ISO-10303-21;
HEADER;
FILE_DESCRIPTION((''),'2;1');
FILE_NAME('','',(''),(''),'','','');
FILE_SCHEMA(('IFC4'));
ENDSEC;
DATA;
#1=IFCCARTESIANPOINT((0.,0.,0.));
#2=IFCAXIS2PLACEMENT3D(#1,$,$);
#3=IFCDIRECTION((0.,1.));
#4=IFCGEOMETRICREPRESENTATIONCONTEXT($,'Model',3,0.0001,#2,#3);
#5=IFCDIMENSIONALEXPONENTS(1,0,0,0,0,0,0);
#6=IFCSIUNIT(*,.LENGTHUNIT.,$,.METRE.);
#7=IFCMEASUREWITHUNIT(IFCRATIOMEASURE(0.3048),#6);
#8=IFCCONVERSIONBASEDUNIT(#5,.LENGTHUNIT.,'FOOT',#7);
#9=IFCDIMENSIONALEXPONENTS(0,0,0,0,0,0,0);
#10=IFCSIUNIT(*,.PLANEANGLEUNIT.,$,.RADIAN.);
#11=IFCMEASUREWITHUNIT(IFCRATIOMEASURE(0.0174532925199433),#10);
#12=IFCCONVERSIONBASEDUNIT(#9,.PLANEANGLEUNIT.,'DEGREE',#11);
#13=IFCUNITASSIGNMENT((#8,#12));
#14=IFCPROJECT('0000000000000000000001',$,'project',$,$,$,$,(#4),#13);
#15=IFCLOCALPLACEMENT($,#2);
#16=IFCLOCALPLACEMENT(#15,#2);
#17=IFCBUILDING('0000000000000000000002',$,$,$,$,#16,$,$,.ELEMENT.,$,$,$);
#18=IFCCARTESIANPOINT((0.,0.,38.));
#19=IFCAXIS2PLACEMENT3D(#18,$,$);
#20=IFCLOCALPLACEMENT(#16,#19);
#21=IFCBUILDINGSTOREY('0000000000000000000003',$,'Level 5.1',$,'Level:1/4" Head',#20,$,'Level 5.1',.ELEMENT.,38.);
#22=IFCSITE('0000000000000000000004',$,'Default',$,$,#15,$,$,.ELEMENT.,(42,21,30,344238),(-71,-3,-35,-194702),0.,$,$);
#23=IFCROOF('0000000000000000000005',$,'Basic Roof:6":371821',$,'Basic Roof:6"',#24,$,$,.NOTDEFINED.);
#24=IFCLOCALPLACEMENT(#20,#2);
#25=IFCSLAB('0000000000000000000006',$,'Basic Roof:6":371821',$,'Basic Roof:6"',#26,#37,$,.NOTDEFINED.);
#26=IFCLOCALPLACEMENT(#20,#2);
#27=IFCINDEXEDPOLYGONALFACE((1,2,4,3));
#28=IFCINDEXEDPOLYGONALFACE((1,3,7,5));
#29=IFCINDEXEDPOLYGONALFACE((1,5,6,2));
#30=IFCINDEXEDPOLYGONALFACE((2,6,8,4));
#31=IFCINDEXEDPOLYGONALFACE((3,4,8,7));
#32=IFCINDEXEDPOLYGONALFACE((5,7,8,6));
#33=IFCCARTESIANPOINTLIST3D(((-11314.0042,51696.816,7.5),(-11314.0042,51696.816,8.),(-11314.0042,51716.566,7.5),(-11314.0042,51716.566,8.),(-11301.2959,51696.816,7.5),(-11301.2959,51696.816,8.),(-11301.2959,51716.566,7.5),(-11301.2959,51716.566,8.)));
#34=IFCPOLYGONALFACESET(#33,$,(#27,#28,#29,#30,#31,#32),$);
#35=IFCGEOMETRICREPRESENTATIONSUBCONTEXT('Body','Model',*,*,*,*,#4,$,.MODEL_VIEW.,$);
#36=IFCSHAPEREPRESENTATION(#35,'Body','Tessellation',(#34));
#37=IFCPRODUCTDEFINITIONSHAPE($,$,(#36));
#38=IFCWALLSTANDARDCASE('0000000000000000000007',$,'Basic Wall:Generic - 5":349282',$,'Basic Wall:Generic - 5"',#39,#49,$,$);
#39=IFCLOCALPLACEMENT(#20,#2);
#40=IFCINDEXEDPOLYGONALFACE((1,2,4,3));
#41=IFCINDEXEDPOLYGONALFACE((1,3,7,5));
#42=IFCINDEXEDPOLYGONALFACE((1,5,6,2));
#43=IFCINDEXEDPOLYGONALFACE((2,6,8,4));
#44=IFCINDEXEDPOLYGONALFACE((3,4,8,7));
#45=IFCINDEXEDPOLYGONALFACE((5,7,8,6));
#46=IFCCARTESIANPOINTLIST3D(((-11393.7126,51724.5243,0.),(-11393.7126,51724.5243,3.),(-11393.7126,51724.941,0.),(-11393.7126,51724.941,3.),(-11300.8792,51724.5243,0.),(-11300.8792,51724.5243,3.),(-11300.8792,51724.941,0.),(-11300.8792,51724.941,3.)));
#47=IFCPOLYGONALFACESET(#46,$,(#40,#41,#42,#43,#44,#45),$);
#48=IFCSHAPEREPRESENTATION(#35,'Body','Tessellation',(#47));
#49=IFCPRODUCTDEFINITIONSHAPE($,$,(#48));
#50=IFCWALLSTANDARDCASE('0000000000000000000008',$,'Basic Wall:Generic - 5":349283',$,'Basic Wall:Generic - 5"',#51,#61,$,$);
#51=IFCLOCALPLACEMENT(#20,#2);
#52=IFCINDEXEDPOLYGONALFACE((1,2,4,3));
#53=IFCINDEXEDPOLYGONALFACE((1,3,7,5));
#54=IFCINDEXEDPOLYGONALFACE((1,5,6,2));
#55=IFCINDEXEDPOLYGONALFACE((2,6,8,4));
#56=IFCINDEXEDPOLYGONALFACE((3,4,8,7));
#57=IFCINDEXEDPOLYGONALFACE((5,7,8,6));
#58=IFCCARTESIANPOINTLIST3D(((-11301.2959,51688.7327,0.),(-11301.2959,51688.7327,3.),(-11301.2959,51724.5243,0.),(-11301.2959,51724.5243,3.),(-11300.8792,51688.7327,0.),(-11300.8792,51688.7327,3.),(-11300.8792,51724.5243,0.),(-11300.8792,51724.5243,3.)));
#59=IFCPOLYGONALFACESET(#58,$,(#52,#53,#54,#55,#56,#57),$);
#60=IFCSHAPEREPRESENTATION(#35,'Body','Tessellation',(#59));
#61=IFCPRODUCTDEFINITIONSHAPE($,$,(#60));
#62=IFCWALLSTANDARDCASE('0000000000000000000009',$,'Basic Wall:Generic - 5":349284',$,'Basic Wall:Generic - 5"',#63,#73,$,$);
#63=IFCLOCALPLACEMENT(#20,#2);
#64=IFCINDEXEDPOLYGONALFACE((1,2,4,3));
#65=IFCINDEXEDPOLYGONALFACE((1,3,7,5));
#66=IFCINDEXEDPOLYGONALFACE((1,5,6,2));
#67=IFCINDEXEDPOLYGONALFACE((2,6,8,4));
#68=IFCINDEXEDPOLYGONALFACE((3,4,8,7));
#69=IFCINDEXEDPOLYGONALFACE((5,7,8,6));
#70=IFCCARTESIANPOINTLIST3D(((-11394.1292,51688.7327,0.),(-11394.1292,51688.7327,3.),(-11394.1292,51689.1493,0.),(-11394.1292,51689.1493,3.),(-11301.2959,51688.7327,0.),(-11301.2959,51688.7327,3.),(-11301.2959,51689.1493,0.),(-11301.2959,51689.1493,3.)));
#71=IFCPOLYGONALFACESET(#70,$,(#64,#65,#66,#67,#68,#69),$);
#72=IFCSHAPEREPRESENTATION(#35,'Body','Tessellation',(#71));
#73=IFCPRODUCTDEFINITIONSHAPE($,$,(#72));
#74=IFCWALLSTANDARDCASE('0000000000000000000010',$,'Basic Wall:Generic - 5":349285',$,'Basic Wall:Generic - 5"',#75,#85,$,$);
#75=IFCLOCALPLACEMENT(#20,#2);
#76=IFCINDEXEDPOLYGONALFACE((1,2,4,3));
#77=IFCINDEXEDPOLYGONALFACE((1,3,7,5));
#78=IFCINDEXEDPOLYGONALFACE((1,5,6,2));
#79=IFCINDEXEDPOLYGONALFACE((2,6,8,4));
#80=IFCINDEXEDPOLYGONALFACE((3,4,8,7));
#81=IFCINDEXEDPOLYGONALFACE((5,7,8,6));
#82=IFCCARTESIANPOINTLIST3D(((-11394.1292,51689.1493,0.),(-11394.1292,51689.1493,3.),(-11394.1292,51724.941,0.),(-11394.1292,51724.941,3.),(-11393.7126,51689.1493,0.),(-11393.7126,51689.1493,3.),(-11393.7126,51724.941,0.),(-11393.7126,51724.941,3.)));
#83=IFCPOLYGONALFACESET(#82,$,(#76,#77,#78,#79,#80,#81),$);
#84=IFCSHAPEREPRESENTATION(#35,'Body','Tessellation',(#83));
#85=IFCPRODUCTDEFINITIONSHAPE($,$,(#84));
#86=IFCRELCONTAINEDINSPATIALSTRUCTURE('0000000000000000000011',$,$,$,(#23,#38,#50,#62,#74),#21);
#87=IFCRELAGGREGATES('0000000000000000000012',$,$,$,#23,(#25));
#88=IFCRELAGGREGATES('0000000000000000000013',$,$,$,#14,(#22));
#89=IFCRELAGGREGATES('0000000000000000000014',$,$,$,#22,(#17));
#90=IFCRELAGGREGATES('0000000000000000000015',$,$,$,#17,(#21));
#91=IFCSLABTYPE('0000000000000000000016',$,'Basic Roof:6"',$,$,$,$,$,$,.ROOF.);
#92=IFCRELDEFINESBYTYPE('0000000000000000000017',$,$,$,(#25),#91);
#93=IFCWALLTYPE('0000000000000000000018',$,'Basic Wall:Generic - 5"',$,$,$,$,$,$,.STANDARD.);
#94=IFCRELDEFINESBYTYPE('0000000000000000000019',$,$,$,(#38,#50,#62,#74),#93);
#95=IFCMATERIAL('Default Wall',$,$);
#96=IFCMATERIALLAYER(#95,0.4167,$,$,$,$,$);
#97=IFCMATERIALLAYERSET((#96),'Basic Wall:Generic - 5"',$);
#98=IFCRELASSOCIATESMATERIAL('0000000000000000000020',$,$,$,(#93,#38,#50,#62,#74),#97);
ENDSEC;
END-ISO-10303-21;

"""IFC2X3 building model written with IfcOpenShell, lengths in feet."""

from ifc_helpers import new_model, entity, si_unit, converted_unit, direction, frame, frame_2d, origin, origin_2d_with_axis, place, context, subcontext, project, spatial, rectangle, extrude, material, layer, layer_set, layer_usage, type_object, element, aggregate, save


model = new_model("IFC2X3")

# Units and contexts
model_context = context("Model", 3, precision=0.0001, world=origin(), true_north=direction((0.0, 1.0)))
body_context = subcontext(model_context, "Body", "Model", "MODEL_VIEW")
ifc_project = project(units=[converted_unit("LENGTHUNIT", "FOOT", entity("IfcRatioMeasure", 0.3048), si_unit("LENGTHUNIT", "METRE"), dimensions=[1, 0, 0, 0, 0, 0, 0]), converted_unit("PLANEANGLEUNIT", "DEGREE", entity("IfcRatioMeasure", 0.0174532925199433), si_unit("PLANEANGLEUNIT", "RADIAN"), dimensions=[0, 0, 0, 0, 0, 0, 0])], contexts=[model_context])

# Site, building, storey
site_placement = place(None, origin())
site = spatial("IfcSite", under=ifc_project, at=site_placement, Name="Default", CompositionType="ELEMENT", RefLatitude=(42, 21, 30, 344238), RefLongitude=(-71, -3, -35, -194702), RefElevation=0.0)
building_placement = place(site_placement, origin())
building = spatial("IfcBuilding", under=site, at=building_placement, CompositionType="ELEMENT")
storey_placement = place(building_placement, frame((0.0, 0.0, 38.0)))
storey = spatial("IfcBuildingStorey", under=building, at=storey_placement, Name="Level 5.1", ObjectType="Level:1/4\" Head", LongName="Level 5.1", CompositionType="ELEMENT", Elevation=38.0)

# Roof, slab
roof_placement = place(storey_placement, frame((-11314.0042, 51696.816, 7.5)))
roof = element("IfcRoof", 1, at=roof_placement, inside=storey, Name="Basic Roof:6\":371821", ObjectType="Basic Roof:6\"", ShapeType="NOTDEFINED")
slab_type = type_object("IfcSlabType", Name="Basic Roof:6\"", PredefinedType="ROOF")
slab_placement = place(roof_placement, origin())
slab = element("IfcSlab", 2, at=slab_placement, type_object=slab_type, Name="Basic Roof:6\":371821", ObjectType="Basic Roof:6\"", PredefinedType="NOTDEFINED", context=body_context, shape_type="SweptSolid", body=[
    extrude(rectangle(XDim=12.7083, YDim=19.75, at=origin_2d_with_axis()), frame((6.3542, 9.875, 0.0)), (0.0, 0.0, 1.0), 0.5),
])
aggregate(roof, [slab])

# Walls
ifc_material = material(Name="Default Wall")
ifc_layer = layer(ifc_material, 0.4167)
ifc_layer_set = layer_set([ifc_layer], Name="Basic Wall:Generic - 5\"")
ifc_layer_usage_1 = layer_usage(ifc_layer_set, "AXIS2", "NEGATIVE", 0.2083)
wall_type = type_object("IfcWallType", Name="Basic Wall:Generic - 5\"", PredefinedType="STANDARD", material=ifc_layer_set)
wall_1_placement = place(storey_placement, frame((-11393.7126, 51724.7327, 0.0)))
element("IfcWallStandardCase", 3, at=wall_1_placement, inside=storey, type_object=wall_type, material=ifc_layer_usage_1, Name="Basic Wall:Generic - 5\":349282", ObjectType="Basic Wall:Generic - 5\"", context=body_context, shape_type="SweptSolid", body=[
    extrude(rectangle(XDim=92.8333, YDim=0.4167, at=frame_2d((46.4167, 0.0), x_axis=(-1.0, 0.0))), origin(), (0.0, 0.0, 1.0), 3.0),
])
ifc_layer_usage_2 = layer_usage(ifc_layer_set, "AXIS2", "NEGATIVE", 0.2083)
wall_2_placement = place(storey_placement, frame((-11301.0876, 51724.5243, 0.0), z_axis=(0.0, 0.0, 1.0), x_axis=(0.0, -1.0, 0.0)))
element("IfcWallStandardCase", 4, at=wall_2_placement, inside=storey, type_object=wall_type, material=ifc_layer_usage_2, Name="Basic Wall:Generic - 5\":349283", ObjectType="Basic Wall:Generic - 5\"", context=body_context, shape_type="SweptSolid", body=[
    extrude(rectangle(XDim=35.7917, YDim=0.4167, at=frame_2d((17.8958, 0.0), x_axis=(-1.0, 0.0))), origin(), (0.0, 0.0, 1.0), 3.0),
])
ifc_layer_usage_3 = layer_usage(ifc_layer_set, "AXIS2", "NEGATIVE", 0.2083)
wall_3_placement = place(storey_placement, frame((-11301.2959, 51688.941, 0.0), z_axis=(0.0, 0.0, 1.0), x_axis=(-1.0, 0.0, 0.0)))
element("IfcWallStandardCase", 5, at=wall_3_placement, inside=storey, type_object=wall_type, material=ifc_layer_usage_3, Name="Basic Wall:Generic - 5\":349284", ObjectType="Basic Wall:Generic - 5\"", context=body_context, shape_type="SweptSolid", body=[
    extrude(rectangle(XDim=92.8333, YDim=0.4167, at=frame_2d((46.4167, 0.0), x_axis=(-1.0, 0.0))), origin(), (0.0, 0.0, 1.0), 3.0),
])
ifc_layer_usage_4 = layer_usage(ifc_layer_set, "AXIS2", "NEGATIVE", 0.2083)
wall_4_placement = place(storey_placement, frame((-11393.9209, 51689.1493, 0.0), z_axis=(0.0, 0.0, 1.0), x_axis=(0.0, 1.0, 0.0)))
element("IfcWallStandardCase", 6, at=wall_4_placement, inside=storey, type_object=wall_type, material=ifc_layer_usage_4, Name="Basic Wall:Generic - 5\":349285", ObjectType="Basic Wall:Generic - 5\"", context=body_context, shape_type="SweptSolid", body=[
    extrude(rectangle(XDim=35.7917, YDim=0.4167, at=frame_2d((17.8958, 0.0), x_axis=(-1.0, 0.0))), origin(), (0.0, 0.0, 1.0), 3.0),
])

save(model, "model.ifc")
